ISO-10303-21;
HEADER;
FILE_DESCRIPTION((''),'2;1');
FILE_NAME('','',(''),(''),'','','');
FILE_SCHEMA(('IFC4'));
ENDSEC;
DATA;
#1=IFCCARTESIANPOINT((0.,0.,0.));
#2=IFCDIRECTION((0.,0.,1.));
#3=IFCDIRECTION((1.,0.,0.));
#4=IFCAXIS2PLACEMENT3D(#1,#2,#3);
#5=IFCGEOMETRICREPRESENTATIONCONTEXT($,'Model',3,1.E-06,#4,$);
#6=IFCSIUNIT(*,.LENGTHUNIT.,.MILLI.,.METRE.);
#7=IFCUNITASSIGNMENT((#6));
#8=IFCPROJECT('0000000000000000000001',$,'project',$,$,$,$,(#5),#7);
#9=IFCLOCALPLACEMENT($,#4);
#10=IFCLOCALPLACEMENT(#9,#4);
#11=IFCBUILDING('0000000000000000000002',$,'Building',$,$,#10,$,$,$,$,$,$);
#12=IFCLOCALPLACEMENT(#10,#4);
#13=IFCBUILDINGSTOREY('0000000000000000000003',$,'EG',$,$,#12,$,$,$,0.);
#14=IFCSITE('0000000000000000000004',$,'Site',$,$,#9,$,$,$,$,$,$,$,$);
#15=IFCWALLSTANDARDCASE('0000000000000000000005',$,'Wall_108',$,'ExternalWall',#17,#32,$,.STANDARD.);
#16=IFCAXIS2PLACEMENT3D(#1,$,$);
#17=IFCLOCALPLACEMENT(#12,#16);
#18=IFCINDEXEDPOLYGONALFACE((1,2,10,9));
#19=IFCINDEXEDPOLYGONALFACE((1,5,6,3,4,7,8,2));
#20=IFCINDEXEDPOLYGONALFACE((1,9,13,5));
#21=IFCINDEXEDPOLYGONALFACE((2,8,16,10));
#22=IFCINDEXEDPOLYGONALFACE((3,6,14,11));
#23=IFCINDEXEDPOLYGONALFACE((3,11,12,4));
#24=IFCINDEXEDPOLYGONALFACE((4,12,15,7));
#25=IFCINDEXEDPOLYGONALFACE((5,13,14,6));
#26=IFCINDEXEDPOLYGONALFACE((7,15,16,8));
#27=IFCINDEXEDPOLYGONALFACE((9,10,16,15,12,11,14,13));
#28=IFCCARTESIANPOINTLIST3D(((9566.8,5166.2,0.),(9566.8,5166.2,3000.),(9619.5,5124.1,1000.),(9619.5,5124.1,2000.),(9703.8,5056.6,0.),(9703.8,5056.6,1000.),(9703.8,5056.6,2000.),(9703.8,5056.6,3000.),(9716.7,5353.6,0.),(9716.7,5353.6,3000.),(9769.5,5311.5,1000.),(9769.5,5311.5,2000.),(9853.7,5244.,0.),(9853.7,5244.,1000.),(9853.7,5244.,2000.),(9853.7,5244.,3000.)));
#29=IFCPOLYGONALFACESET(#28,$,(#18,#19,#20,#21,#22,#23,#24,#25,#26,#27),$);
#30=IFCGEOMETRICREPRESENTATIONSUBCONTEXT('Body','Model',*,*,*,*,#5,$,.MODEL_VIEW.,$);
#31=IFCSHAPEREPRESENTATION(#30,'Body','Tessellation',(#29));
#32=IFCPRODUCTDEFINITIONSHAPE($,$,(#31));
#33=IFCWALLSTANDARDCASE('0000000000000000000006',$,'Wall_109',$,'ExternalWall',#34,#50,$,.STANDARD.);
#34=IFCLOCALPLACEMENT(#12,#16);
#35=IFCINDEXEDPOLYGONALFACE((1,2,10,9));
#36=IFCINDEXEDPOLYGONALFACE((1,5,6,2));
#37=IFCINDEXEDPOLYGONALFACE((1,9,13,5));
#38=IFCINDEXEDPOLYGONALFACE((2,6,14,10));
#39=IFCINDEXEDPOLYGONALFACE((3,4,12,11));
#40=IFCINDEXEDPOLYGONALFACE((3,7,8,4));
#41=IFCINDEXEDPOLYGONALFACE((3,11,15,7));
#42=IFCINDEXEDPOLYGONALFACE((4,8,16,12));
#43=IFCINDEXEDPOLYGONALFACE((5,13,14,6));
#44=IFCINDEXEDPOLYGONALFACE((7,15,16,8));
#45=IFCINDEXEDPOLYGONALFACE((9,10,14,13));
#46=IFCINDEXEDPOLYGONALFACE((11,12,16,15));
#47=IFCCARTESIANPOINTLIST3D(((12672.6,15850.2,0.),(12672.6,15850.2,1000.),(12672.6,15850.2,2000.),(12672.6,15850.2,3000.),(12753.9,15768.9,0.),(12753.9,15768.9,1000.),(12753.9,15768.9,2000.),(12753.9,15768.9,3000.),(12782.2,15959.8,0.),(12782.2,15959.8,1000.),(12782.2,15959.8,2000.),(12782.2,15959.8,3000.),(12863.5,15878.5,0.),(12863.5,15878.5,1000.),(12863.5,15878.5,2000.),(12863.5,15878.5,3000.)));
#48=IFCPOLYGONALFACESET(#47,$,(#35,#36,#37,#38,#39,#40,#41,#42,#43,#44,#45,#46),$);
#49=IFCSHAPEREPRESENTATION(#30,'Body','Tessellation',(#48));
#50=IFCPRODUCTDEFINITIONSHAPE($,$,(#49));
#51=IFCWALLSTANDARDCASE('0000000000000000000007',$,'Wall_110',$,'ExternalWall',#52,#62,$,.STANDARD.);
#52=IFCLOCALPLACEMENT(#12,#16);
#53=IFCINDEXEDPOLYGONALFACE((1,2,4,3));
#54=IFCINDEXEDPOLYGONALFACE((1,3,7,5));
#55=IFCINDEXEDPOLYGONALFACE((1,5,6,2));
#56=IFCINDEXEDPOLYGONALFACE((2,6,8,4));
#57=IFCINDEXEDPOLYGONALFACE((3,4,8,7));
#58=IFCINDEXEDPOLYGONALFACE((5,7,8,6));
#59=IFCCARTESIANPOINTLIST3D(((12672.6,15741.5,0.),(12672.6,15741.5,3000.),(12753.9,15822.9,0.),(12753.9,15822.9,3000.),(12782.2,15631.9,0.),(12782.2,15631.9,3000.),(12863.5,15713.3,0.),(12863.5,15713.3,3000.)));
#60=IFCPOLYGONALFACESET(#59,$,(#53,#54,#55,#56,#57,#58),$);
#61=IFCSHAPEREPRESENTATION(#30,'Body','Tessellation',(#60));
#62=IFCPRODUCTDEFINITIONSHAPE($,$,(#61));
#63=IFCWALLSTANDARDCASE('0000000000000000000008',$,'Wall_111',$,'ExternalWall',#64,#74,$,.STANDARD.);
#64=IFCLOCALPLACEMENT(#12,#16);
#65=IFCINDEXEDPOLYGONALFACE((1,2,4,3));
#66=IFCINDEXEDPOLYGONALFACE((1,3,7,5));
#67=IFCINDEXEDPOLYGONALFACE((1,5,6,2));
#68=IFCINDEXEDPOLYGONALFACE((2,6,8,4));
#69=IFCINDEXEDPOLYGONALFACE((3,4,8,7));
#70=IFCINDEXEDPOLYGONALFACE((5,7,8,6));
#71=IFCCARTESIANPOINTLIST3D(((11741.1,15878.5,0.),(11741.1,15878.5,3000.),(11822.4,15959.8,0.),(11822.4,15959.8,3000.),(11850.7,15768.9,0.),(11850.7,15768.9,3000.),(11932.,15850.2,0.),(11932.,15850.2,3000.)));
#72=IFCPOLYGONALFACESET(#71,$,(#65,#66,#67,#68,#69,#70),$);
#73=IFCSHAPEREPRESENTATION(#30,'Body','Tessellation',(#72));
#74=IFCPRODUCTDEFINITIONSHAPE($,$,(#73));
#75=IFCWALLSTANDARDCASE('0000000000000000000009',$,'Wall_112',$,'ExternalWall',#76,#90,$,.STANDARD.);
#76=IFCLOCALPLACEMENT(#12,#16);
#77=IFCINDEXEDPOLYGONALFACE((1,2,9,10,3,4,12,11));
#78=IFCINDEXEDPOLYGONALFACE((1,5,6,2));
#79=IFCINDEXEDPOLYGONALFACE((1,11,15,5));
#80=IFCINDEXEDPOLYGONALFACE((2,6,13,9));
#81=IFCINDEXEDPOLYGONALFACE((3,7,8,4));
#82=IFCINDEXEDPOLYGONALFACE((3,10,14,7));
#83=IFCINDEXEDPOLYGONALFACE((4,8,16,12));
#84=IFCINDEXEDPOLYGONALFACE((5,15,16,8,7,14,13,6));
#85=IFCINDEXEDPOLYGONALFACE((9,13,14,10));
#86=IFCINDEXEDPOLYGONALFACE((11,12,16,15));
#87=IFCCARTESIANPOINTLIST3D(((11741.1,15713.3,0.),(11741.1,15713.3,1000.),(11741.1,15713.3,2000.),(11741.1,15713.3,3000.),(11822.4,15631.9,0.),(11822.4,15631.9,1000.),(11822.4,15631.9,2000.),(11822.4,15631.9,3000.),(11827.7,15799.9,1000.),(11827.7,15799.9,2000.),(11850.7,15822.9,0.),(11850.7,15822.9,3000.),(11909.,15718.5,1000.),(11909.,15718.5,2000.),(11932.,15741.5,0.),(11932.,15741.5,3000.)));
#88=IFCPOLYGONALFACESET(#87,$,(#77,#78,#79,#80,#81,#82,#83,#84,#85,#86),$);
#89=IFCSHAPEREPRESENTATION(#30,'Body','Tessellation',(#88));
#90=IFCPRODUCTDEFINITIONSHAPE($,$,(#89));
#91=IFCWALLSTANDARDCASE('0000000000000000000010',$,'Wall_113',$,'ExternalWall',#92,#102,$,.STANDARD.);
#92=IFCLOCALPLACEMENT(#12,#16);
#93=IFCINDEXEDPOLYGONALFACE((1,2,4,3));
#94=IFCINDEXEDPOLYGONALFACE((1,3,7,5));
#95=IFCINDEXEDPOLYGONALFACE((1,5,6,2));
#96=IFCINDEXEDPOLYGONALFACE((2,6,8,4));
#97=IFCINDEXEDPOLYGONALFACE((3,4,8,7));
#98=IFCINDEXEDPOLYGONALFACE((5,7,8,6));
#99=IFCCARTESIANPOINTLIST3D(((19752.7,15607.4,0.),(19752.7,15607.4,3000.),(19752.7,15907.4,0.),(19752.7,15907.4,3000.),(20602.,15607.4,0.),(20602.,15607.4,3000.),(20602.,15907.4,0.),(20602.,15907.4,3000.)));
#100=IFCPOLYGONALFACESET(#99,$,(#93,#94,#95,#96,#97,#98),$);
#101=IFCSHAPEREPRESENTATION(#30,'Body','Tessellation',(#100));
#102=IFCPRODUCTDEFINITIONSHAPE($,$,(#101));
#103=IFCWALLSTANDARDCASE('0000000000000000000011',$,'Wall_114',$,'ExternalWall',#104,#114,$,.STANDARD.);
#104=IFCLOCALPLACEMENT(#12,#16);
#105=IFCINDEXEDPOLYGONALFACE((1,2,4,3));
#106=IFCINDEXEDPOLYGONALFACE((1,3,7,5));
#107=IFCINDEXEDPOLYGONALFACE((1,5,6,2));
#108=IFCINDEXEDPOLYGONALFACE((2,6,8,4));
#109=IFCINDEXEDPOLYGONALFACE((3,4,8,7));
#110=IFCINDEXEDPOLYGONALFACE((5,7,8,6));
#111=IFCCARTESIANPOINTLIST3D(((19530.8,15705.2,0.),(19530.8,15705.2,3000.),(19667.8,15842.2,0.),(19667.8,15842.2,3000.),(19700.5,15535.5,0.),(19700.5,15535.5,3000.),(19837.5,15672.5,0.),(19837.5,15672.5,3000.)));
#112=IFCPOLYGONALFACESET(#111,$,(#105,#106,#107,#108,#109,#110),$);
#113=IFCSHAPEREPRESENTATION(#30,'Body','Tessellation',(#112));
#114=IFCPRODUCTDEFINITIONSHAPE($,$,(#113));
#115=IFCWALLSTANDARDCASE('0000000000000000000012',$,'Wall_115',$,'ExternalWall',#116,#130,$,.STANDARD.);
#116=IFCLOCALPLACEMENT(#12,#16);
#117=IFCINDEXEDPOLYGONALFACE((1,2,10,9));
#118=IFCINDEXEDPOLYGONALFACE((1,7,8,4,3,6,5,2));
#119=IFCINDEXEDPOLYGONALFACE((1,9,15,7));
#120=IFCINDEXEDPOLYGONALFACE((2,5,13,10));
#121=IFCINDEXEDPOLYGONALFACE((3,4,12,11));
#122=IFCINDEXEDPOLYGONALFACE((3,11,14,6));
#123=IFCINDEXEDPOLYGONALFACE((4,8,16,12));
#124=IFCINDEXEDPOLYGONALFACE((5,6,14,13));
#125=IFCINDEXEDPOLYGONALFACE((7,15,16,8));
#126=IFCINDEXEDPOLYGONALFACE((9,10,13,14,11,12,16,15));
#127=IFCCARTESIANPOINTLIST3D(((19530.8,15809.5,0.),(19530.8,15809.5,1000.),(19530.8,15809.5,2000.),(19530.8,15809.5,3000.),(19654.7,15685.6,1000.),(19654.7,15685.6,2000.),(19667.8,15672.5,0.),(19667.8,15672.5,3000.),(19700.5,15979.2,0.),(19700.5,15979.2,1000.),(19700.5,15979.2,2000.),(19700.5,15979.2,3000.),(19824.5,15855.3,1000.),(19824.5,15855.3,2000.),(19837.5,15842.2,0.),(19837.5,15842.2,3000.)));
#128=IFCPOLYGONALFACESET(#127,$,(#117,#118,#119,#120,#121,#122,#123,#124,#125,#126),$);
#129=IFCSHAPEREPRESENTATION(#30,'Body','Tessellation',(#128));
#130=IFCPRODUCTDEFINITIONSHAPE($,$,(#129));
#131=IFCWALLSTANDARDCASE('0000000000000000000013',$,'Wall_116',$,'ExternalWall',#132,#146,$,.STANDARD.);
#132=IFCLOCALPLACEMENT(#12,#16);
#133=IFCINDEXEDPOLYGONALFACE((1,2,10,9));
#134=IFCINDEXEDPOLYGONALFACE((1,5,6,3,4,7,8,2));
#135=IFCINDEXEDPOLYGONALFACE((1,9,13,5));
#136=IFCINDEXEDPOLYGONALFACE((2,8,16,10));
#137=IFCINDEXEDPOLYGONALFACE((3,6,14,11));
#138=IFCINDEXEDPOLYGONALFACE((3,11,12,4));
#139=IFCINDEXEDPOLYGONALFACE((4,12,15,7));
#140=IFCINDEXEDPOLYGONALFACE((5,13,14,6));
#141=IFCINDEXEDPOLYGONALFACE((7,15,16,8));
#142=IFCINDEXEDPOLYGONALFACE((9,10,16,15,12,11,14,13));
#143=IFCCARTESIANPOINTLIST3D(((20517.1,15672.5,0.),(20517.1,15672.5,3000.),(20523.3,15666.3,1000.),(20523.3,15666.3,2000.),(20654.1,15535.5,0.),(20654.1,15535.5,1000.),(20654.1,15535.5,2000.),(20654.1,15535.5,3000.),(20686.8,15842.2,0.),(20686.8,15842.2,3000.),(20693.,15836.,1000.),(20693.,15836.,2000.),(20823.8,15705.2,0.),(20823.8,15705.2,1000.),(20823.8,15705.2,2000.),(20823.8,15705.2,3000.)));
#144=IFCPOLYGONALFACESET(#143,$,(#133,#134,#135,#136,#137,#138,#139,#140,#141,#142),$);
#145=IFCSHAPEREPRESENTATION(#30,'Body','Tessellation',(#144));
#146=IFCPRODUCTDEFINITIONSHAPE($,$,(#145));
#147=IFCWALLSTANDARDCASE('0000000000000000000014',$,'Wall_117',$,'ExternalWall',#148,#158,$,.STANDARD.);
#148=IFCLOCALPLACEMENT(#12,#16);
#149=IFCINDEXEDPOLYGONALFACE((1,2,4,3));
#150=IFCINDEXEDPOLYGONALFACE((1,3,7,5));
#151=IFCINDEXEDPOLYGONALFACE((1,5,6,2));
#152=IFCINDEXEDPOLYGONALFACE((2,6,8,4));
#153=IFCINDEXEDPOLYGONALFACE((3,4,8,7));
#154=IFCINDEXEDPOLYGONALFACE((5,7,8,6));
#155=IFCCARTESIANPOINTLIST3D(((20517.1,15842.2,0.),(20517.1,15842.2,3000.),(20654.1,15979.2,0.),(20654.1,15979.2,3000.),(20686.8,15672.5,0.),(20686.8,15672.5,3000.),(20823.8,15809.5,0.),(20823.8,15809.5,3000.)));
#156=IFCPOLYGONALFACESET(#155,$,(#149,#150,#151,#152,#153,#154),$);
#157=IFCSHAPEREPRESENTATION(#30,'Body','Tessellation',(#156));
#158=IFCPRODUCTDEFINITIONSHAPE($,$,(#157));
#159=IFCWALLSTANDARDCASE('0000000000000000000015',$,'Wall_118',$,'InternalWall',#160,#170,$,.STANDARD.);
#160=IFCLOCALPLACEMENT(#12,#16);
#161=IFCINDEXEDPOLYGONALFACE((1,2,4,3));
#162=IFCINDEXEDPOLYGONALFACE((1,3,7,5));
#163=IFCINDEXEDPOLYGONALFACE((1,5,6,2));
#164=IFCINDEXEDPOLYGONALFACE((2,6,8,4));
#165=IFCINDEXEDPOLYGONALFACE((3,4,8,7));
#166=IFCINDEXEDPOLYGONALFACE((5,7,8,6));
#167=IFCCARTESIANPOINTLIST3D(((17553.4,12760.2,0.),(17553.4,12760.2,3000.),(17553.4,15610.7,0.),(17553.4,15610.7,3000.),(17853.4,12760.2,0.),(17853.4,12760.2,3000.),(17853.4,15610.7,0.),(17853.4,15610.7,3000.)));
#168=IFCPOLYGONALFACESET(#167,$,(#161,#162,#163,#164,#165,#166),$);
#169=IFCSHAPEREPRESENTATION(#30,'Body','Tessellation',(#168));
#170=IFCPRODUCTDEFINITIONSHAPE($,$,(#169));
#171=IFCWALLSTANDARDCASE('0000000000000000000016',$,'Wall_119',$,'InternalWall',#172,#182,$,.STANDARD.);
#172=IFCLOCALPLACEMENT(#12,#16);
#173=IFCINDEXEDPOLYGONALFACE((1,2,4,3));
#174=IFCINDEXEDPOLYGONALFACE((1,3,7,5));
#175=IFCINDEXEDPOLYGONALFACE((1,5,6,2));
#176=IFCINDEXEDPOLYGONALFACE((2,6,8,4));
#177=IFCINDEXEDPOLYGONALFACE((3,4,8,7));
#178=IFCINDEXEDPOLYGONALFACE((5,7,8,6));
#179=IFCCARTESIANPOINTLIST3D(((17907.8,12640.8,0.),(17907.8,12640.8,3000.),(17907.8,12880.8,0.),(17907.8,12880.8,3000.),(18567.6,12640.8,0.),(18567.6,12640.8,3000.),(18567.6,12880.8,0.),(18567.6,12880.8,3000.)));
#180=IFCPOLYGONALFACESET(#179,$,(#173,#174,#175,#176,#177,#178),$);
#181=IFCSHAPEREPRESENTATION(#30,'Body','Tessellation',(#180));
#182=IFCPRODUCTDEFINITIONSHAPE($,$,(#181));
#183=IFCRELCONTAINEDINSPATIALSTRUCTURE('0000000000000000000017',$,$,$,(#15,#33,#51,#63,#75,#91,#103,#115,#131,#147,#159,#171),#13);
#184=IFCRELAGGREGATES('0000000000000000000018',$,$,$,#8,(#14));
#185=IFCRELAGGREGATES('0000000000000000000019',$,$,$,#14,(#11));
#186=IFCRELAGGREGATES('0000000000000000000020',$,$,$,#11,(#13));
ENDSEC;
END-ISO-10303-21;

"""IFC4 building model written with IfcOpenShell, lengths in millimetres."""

from ifc_helpers import new_model, si_unit, frame, origin_with_axes, place, context, subcontext, project, spatial, rectangle, extrude, element, save


model = new_model("IFC4")

# Units and contexts
model_context = context("Model", 3, precision=1e-06, world=origin_with_axes())
body_context = subcontext(model_context, "Body", "Model", "MODEL_VIEW")
ifc_project = project(units=[si_unit("LENGTHUNIT", "METRE", prefix="MILLI")], contexts=[model_context])

# Site, building, storey
site_placement = place(None, origin_with_axes())
site = spatial("IfcSite", under=ifc_project, at=site_placement, Name="Site")
building_placement = place(site_placement, origin_with_axes())
building = spatial("IfcBuilding", under=site, at=building_placement, Name="Building")
storey_placement = place(building_placement, origin_with_axes())
storey = spatial("IfcBuildingStorey", under=building, at=storey_placement, Name="EG", Elevation=0.0)

# Walls, openings
wall_1_placement = place(storey_placement, origin_with_axes())
wall_1 = element("IfcWallStandardCase", 1, at=wall_1_placement, inside=storey, Name="Wall_108", ObjectType="ExternalWall", PredefinedType="STANDARD", context=body_context, shape_type="SweptSolid", body=[
    extrude(rectangle(XDim=175.4, YDim=240.0), frame((9710.3, 5205.1, 0.0), z_axis=(0.0, 0.0, 1.0), x_axis=(0.780869, -0.624695, 0.0)), (0.0, 0.0, 1.0), 3000.0),
])
opening_1_placement = place(wall_1_placement, origin_with_axes())
element("IfcOpeningElement", 2, at=opening_1_placement, inside=storey, cuts=wall_1, context=body_context, shape_type="SweptSolid", body=[
    extrude(rectangle(XDim=1199.0, YDim=240.0), frame((10162.6, 4843.3, 1000.0), z_axis=(0.0, 0.0, 1.0), x_axis=(0.780869, -0.624695, 0.0)), (0.0, 0.0, 1.0), 1000.0),
])
wall_2_placement = place(storey_placement, origin_with_axes())
wall_2 = element("IfcWallStandardCase", 3, at=wall_2_placement, inside=storey, Name="Wall_109", ObjectType="ExternalWall", PredefinedType="STANDARD", context=body_context, shape_type="SweptSolid", body=[
    extrude(rectangle(XDim=155.0, YDim=115.0), frame((12768.1, 15864.4, 0.0), z_axis=(0.0, 0.0, 1.0), x_axis=(0.707107, 0.707107, 0.0)), (0.0, 0.0, 1.0), 3000.0),
])
opening_2_placement = place(wall_2_placement, origin_with_axes())
element("IfcOpeningElement", 4, at=opening_2_placement, inside=storey, cuts=wall_2, context=body_context, shape_type="SweptSolid", body=[
    extrude(rectangle(XDim=1089.4, YDim=115.0), frame((13081.7, 16178.0, 1000.0), z_axis=(0.0, 0.0, 1.0), x_axis=(0.707107, 0.707107, 0.0)), (0.0, 0.0, 1.0), 1000.0),
])

# Walls
wall_3_placement = place(storey_placement, origin_with_axes())
element("IfcWallStandardCase", 5, at=wall_3_placement, inside=storey, Name="Wall_110", ObjectType="ExternalWall", PredefinedType="STANDARD", context=body_context, shape_type="SweptSolid", body=[
    extrude(rectangle(XDim=155.0, YDim=115.0), frame((12768.1, 15727.4, 0.0), z_axis=(0.0, 0.0, 1.0), x_axis=(0.707107, -0.707107, 0.0)), (0.0, 0.0, 1.0), 3000.0),
])
wall_4_placement = place(storey_placement, origin_with_axes())
element("IfcWallStandardCase", 6, at=wall_4_placement, inside=storey, Name="Wall_111", ObjectType="ExternalWall", PredefinedType="STANDARD", context=body_context, shape_type="SweptSolid", body=[
    extrude(rectangle(XDim=155.0, YDim=115.0), frame((11836.6, 15864.4, 0.0), z_axis=(0.0, 0.0, 1.0), x_axis=(-0.707107, 0.707107, 0.0)), (0.0, 0.0, 1.0), 3000.0),
])

# Wall, opening
wall_5_placement = place(storey_placement, origin_with_axes())
wall_5 = element("IfcWallStandardCase", 7, at=wall_5_placement, inside=storey, Name="Wall_112", ObjectType="ExternalWall", PredefinedType="STANDARD", context=body_context, shape_type="SweptSolid", body=[
    extrude(rectangle(XDim=155.0, YDim=115.0), frame((11836.6, 15727.4, 0.0), z_axis=(0.0, 0.0, 1.0), x_axis=(-0.707107, -0.707107, 0.0)), (0.0, 0.0, 1.0), 3000.0),
])
opening_3_placement = place(wall_5_placement, origin_with_axes())
element("IfcOpeningElement", 8, at=opening_3_placement, inside=storey, cuts=wall_5, context=body_context, shape_type="SweptSolid", body=[
    extrude(rectangle(XDim=1144.8, YDim=115.0), frame((11463.6, 15354.5, 1000.0), z_axis=(0.0, 0.0, 1.0), x_axis=(-0.707107, -0.707107, 0.0)), (0.0, 0.0, 1.0), 1000.0),
])

# Walls
wall_6_placement = place(storey_placement, origin_with_axes())
element("IfcWallStandardCase", 9, at=wall_6_placement, inside=storey, Name="Wall_113", ObjectType="ExternalWall", PredefinedType="STANDARD", context=body_context, shape_type="SweptSolid", body=[
    extrude(rectangle(XDim=849.3, YDim=300.0), frame((20177.3, 15757.4, 0.0), z_axis=(0.0, 0.0, 1.0), x_axis=(-1.0, 0.0, 0.0)), (0.0, 0.0, 1.0), 3000.0),
])
wall_7_placement = place(storey_placement, origin_with_axes())
element("IfcWallStandardCase", 10, at=wall_7_placement, inside=storey, Name="Wall_114", ObjectType="ExternalWall", PredefinedType="STANDARD", context=body_context, shape_type="SweptSolid", body=[
    extrude(rectangle(XDim=193.7, YDim=240.0), frame((19684.2, 15688.9, 0.0), z_axis=(0.0, 0.0, 1.0), x_axis=(-0.707107, -0.707107, 0.0)), (0.0, 0.0, 1.0), 3000.0),
])

# Walls, openings
wall_8_placement = place(storey_placement, origin_with_axes())
wall_8 = element("IfcWallStandardCase", 11, at=wall_8_placement, inside=storey, Name="Wall_115", ObjectType="ExternalWall", PredefinedType="STANDARD", context=body_context, shape_type="SweptSolid", body=[
    extrude(rectangle(XDim=193.7, YDim=240.0), frame((19684.2, 15825.9, 0.0), z_axis=(0.0, 0.0, 1.0), x_axis=(-0.707107, 0.707107, 0.0)), (0.0, 0.0, 1.0), 3000.0),
])
opening_4_placement = place(wall_8_placement, origin_with_axes())
element("IfcOpeningElement", 12, at=opening_4_placement, inside=storey, cuts=wall_8, context=body_context, shape_type="SweptSolid", body=[
    extrude(rectangle(XDim=1107.9, YDim=240.0), frame((19347.9, 16162.1, 1000.0), z_axis=(0.0, 0.0, 1.0), x_axis=(-0.707107, 0.707107, 0.0)), (0.0, 0.0, 1.0), 1000.0),
])
wall_9_placement = place(storey_placement, origin_with_axes())
wall_9 = element("IfcWallStandardCase", 13, at=wall_9_placement, inside=storey, Name="Wall_116", ObjectType="ExternalWall", PredefinedType="STANDARD", context=body_context, shape_type="SweptSolid", body=[
    extrude(rectangle(XDim=193.7, YDim=240.0), frame((20670.5, 15688.9, 0.0), z_axis=(0.0, 0.0, 1.0), x_axis=(0.707107, -0.707107, 0.0)), (0.0, 0.0, 1.0), 3000.0),
])
opening_5_placement = place(wall_9_placement, origin_with_axes())
element("IfcOpeningElement", 14, at=opening_5_placement, inside=storey, cuts=wall_9, context=body_context, shape_type="SweptSolid", body=[
    extrude(rectangle(XDim=2068.0, YDim=240.0), frame((21339.3, 15020.0, 1000.0), z_axis=(0.0, 0.0, 1.0), x_axis=(0.707107, -0.707107, 0.0)), (0.0, 0.0, 1.0), 1000.0),
])

# Walls
wall_10_placement = place(storey_placement, origin_with_axes())
element("IfcWallStandardCase", 15, at=wall_10_placement, inside=storey, Name="Wall_117", ObjectType="ExternalWall", PredefinedType="STANDARD", context=body_context, shape_type="SweptSolid", body=[
    extrude(rectangle(XDim=193.7, YDim=240.0), frame((20670.5, 15825.9, 0.0), z_axis=(0.0, 0.0, 1.0), x_axis=(0.707107, 0.707107, 0.0)), (0.0, 0.0, 1.0), 3000.0),
])
wall_11_placement = place(storey_placement, origin_with_axes())
element("IfcWallStandardCase", 16, at=wall_11_placement, inside=storey, Name="Wall_118", ObjectType="InternalWall", PredefinedType="STANDARD", context=body_context, shape_type="SweptSolid", body=[
    extrude(rectangle(XDim=2850.5, YDim=300.0), frame((17703.4, 14185.4, 0.0), z_axis=(0.0, 0.0, 1.0), x_axis=(0.0, -1.0, 0.0)), (0.0, 0.0, 1.0), 3000.0),
])
wall_12_placement = place(storey_placement, origin_with_axes())
element("IfcWallStandardCase", 17, at=wall_12_placement, inside=storey, Name="Wall_119", ObjectType="InternalWall", PredefinedType="STANDARD", context=body_context, shape_type="SweptSolid", body=[
    extrude(rectangle(XDim=659.8, YDim=240.0), frame((18237.7, 12760.8, 0.0), z_axis=(0.0, 0.0, 1.0), x_axis=(-1.0, 0.0, 0.0)), (0.0, 0.0, 1.0), 3000.0),
])

save(model, "model.ifc")
